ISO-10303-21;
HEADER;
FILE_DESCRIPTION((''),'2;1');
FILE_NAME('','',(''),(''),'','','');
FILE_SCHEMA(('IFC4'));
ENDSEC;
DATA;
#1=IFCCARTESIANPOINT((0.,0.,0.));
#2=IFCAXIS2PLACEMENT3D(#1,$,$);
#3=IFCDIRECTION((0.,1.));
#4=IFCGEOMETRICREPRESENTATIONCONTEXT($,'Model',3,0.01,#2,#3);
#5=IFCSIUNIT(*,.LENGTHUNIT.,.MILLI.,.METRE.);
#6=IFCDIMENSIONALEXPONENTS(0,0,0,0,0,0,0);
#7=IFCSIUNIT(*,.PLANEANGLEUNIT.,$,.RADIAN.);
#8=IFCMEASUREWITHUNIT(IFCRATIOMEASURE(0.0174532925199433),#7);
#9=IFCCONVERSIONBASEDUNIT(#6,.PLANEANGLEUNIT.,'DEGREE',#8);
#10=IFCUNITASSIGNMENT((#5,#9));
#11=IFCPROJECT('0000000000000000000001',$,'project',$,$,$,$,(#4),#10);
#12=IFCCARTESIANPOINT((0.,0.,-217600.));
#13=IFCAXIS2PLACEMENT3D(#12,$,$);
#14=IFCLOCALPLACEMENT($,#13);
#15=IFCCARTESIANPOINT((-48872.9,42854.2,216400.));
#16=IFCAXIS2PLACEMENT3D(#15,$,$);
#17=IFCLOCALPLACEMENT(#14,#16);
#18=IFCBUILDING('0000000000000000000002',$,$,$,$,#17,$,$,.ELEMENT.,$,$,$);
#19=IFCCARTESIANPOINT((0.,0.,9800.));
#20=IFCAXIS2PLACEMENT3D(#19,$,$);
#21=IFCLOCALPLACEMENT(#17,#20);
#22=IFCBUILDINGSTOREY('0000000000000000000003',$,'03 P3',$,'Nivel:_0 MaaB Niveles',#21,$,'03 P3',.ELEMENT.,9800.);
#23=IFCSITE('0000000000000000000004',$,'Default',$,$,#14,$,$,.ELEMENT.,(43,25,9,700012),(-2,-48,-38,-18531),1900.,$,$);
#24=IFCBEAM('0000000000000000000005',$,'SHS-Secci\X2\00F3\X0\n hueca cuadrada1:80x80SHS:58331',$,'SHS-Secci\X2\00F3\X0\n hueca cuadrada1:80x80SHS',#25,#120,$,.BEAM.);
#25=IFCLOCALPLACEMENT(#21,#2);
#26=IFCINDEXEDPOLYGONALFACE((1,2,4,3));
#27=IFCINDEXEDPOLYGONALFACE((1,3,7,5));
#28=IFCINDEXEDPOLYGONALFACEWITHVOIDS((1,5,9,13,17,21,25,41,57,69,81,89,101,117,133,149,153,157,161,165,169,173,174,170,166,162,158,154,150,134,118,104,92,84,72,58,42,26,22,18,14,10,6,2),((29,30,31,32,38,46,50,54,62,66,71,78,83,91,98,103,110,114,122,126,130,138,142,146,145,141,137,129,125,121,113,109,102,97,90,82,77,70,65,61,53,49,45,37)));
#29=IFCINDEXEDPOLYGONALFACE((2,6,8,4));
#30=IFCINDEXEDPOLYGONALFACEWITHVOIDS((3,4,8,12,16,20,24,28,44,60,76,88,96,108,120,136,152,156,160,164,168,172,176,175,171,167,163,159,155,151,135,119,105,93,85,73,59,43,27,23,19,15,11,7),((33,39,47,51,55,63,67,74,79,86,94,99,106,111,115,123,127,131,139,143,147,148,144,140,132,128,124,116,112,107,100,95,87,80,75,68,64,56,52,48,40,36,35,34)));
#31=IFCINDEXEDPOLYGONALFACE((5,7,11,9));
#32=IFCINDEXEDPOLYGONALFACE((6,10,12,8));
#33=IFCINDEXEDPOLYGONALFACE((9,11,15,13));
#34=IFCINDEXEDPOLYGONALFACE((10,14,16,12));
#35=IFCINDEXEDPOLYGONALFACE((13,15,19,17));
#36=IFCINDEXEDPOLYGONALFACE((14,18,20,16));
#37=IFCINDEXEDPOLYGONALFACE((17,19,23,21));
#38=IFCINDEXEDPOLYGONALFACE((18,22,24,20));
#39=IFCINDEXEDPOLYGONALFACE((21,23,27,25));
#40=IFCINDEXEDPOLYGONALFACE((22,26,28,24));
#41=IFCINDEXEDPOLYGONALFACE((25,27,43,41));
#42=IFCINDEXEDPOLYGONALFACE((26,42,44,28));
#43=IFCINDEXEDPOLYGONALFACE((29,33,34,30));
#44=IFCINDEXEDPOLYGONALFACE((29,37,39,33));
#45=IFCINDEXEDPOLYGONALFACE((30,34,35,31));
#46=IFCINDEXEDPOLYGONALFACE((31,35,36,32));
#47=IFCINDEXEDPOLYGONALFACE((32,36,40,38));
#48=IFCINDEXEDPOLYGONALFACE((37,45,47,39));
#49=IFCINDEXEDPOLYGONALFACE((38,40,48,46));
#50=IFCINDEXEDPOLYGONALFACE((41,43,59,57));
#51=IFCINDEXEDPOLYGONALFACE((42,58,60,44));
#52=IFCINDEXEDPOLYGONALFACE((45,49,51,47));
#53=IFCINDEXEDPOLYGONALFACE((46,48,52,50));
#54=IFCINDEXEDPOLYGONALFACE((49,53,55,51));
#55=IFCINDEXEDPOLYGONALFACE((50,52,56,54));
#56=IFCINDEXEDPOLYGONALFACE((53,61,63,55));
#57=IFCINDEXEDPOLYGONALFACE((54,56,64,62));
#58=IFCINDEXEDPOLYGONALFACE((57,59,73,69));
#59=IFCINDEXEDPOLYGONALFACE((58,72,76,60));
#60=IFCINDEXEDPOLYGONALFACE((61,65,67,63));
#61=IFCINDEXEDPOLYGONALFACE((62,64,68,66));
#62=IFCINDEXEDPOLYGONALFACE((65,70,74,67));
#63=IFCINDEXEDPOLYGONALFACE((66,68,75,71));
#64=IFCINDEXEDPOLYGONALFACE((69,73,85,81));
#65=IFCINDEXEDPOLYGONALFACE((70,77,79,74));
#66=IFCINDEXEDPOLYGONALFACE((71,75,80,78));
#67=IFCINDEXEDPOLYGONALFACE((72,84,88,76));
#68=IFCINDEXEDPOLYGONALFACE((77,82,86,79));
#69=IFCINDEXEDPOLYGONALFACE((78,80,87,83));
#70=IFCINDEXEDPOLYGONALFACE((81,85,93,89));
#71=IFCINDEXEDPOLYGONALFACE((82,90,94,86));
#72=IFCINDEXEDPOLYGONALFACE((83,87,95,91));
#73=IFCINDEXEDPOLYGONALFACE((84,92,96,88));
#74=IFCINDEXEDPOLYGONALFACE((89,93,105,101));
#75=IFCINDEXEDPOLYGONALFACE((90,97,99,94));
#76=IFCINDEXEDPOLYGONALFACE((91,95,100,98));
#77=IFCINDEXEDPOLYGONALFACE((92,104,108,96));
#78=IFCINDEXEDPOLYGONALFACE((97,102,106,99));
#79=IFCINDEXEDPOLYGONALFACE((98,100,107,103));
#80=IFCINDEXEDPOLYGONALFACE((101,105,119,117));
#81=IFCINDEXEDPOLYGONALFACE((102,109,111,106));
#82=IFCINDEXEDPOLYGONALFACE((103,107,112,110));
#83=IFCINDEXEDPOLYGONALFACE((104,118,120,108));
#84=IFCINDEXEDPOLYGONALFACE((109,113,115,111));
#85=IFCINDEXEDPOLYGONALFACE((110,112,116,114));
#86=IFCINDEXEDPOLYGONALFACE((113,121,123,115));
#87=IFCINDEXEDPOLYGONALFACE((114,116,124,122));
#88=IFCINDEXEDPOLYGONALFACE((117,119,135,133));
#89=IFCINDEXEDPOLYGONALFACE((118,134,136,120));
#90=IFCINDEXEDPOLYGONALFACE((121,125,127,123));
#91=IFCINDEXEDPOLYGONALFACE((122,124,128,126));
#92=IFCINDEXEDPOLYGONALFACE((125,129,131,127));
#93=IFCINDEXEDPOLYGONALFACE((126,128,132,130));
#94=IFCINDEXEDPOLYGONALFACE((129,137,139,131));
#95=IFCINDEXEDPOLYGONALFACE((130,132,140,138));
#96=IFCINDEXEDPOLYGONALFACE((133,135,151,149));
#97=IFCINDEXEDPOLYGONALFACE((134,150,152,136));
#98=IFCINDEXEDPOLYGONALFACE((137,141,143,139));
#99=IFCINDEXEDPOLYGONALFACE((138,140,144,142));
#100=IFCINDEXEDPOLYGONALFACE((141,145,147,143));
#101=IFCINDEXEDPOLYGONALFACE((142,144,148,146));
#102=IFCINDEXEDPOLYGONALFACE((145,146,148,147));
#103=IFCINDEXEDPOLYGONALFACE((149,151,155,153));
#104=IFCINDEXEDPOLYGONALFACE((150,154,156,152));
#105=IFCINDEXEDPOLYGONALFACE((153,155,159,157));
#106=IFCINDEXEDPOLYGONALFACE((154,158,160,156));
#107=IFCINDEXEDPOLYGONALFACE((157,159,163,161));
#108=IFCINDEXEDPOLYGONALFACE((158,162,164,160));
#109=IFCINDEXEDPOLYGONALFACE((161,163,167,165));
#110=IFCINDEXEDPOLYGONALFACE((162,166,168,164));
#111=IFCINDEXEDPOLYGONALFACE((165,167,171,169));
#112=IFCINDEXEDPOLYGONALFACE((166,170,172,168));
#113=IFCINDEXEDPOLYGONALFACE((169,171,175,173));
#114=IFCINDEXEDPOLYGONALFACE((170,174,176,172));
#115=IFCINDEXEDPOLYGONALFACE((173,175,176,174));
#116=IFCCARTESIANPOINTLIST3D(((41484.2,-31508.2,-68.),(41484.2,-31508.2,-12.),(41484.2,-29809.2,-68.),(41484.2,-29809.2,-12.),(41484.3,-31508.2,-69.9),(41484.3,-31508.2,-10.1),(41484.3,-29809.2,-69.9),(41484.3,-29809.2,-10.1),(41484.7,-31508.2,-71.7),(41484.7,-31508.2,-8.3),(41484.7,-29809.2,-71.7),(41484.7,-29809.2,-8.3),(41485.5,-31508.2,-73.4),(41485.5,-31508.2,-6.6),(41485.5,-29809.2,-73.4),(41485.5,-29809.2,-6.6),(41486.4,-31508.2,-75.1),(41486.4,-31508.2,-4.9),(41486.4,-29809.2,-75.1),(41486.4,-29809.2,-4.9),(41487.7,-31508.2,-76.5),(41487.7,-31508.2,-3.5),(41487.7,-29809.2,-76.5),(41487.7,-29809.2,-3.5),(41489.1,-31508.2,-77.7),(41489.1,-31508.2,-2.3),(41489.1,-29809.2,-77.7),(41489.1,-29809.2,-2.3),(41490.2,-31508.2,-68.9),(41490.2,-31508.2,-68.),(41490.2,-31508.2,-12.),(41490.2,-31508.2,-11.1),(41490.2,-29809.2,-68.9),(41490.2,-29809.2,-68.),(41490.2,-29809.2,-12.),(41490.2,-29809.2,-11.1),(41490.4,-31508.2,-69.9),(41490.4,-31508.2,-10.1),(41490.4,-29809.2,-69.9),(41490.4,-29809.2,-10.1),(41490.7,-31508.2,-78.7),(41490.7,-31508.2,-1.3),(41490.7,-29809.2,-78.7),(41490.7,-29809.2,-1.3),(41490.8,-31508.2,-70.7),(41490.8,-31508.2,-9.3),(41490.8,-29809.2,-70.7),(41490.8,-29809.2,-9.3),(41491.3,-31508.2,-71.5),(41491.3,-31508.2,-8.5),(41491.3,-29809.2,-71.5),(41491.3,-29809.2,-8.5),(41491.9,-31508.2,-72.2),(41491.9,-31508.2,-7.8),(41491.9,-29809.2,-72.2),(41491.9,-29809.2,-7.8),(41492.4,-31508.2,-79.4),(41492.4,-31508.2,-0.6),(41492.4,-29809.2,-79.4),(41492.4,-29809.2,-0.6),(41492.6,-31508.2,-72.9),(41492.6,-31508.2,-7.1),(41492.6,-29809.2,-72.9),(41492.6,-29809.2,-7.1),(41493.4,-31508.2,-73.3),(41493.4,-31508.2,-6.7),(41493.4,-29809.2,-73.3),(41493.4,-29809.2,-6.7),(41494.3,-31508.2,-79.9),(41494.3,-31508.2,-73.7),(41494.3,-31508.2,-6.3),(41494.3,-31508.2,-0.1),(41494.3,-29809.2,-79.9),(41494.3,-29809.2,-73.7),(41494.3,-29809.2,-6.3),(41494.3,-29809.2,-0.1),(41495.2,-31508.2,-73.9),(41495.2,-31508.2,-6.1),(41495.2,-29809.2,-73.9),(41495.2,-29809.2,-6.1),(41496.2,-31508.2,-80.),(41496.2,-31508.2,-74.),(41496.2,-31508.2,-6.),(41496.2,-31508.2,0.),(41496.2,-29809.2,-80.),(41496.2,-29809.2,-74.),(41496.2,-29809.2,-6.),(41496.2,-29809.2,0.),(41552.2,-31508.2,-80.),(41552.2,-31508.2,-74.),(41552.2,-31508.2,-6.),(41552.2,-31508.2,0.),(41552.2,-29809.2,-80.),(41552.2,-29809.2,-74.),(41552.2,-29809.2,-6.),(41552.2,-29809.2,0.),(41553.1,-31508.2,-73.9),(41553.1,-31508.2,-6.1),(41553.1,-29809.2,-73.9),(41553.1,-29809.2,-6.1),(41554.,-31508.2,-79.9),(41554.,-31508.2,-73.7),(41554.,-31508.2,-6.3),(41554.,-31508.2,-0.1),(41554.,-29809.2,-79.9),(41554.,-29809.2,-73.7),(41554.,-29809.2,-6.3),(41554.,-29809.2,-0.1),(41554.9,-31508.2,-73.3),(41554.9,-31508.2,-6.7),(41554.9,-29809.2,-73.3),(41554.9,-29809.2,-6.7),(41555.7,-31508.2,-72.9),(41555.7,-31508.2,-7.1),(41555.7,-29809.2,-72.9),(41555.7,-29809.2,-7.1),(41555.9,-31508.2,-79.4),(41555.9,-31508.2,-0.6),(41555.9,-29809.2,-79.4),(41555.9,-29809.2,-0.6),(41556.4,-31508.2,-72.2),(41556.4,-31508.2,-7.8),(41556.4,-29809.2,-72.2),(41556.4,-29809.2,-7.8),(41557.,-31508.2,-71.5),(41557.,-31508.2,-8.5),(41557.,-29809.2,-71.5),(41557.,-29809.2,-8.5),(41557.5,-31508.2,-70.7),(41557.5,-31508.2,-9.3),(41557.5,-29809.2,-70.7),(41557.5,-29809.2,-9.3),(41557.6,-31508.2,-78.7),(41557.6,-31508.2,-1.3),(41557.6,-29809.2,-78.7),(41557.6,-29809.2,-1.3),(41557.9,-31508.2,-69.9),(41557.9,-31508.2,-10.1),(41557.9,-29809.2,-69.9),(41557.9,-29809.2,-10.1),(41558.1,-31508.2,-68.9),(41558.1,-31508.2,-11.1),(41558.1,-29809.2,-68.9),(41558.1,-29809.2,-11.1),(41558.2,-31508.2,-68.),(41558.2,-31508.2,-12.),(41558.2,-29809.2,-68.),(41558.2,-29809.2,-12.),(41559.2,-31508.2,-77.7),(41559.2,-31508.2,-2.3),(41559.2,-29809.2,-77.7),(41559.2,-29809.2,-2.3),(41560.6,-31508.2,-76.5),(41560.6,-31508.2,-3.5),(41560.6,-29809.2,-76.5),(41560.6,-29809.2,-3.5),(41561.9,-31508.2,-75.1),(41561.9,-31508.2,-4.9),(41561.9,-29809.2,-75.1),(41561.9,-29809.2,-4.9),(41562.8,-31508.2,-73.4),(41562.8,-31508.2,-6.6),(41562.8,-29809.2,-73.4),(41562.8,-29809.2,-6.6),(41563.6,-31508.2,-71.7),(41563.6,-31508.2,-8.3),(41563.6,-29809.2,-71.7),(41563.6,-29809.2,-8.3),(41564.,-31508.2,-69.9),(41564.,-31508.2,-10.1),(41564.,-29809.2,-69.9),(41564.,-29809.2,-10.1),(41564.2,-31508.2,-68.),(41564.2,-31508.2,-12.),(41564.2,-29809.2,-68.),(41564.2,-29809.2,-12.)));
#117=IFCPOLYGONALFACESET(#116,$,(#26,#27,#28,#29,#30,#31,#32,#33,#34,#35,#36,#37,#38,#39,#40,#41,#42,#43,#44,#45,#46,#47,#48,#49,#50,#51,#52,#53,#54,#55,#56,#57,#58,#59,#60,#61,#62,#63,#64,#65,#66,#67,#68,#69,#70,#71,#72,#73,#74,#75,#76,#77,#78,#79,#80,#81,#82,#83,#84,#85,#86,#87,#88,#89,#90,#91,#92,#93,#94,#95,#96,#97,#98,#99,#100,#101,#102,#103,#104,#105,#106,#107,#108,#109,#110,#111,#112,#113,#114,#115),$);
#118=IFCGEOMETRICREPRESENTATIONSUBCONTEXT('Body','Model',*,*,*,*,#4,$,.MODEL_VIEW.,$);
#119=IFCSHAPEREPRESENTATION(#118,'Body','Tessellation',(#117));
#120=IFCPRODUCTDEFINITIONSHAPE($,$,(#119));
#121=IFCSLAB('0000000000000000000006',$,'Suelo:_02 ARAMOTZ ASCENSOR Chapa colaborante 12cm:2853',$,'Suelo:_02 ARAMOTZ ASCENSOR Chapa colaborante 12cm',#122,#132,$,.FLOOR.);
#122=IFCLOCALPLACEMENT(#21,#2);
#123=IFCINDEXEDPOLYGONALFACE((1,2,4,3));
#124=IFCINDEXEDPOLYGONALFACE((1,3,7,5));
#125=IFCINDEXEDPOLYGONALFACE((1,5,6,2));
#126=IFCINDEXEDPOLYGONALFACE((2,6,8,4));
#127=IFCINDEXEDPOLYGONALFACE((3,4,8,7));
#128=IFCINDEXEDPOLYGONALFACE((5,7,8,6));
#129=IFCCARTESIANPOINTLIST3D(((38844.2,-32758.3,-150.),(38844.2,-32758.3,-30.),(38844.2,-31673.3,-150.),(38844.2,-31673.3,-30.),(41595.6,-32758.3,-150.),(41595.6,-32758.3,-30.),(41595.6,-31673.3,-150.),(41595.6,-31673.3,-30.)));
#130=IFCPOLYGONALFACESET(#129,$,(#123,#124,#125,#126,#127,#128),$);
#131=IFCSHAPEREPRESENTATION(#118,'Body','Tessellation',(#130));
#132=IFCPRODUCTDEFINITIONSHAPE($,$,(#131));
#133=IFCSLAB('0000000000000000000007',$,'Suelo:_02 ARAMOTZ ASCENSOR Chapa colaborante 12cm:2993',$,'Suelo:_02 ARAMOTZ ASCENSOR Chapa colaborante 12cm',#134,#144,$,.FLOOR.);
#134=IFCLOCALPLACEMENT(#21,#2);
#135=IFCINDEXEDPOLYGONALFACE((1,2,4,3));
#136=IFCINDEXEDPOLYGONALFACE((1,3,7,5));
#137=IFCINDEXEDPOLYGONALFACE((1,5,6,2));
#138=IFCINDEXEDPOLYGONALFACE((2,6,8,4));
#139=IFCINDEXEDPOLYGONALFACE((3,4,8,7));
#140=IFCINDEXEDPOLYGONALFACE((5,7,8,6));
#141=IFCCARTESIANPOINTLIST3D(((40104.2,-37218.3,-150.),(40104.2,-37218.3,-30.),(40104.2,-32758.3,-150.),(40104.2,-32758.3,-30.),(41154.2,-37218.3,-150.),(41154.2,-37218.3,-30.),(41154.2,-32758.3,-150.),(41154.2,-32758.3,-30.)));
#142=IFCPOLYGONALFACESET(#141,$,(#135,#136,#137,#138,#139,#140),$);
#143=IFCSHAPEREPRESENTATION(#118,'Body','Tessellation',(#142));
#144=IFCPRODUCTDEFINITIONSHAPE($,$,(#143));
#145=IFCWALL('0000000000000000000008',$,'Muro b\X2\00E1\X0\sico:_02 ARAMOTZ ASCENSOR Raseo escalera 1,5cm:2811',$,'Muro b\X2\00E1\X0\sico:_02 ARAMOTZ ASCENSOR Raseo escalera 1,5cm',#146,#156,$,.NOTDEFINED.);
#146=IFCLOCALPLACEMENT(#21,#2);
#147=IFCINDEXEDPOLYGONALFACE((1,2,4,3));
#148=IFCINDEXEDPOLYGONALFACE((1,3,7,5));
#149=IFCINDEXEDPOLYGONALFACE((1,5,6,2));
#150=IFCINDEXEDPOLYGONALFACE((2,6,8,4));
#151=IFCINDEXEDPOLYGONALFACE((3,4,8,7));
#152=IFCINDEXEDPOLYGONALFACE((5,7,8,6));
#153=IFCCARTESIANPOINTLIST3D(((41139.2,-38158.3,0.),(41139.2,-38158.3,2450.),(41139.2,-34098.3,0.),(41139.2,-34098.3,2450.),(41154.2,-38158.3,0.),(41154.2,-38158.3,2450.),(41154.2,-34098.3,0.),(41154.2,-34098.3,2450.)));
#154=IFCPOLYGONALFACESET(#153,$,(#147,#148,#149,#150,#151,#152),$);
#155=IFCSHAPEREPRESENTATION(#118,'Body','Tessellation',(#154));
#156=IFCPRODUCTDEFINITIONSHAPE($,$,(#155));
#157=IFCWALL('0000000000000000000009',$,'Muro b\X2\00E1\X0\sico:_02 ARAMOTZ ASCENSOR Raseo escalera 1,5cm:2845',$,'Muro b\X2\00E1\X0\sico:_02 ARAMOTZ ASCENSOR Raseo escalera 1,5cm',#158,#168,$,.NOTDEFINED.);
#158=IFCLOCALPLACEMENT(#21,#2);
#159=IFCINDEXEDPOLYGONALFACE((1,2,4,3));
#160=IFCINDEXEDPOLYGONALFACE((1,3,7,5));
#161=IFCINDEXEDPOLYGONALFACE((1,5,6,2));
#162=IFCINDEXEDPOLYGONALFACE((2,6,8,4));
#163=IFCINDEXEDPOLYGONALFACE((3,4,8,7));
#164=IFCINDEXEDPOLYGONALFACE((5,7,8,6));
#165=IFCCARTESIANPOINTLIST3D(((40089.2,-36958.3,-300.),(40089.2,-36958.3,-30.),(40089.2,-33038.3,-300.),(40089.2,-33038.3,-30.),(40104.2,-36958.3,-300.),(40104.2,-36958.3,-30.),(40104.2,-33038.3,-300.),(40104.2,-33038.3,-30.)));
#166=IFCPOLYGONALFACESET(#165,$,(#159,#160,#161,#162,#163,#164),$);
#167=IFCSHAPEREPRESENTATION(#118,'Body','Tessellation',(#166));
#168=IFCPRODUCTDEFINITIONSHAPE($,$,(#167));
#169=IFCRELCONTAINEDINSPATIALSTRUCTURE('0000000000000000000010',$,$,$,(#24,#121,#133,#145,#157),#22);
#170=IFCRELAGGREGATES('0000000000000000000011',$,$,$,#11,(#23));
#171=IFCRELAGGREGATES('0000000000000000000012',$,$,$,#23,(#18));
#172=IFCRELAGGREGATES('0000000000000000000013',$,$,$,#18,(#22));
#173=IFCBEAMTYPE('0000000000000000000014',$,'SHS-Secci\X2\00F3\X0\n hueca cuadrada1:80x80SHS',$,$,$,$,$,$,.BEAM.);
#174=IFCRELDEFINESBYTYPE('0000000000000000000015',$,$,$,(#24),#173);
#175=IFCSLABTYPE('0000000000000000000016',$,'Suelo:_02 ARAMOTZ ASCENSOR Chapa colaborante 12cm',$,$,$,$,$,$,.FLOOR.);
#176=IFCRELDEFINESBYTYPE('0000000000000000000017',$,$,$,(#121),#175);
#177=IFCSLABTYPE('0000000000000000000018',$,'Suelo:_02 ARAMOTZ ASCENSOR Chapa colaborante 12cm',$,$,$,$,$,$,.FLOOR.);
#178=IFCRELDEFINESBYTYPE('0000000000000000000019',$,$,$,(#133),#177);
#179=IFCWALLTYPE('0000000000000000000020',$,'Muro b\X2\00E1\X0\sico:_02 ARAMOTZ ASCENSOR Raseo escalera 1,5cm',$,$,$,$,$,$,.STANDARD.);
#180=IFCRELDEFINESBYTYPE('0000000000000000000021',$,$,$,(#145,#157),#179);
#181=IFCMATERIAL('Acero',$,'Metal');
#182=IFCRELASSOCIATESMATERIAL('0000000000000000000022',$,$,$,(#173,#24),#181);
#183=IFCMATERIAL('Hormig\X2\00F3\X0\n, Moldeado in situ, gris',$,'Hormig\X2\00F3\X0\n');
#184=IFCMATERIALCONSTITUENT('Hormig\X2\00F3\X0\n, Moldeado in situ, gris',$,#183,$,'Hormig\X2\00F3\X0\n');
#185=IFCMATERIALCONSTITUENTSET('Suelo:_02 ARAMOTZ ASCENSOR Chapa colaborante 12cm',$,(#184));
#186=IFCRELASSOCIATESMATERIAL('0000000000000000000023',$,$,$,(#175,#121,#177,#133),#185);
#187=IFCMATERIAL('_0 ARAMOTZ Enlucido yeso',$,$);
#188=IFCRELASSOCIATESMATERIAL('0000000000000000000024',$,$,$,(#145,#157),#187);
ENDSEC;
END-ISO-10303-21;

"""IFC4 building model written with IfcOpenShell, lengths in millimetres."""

from ifc_helpers import new_model, entity, si_unit, converted_unit, direction, frame, origin, place, context, subcontext, project, spatial, indexed_curve, outline, extrude, source, transform, mapped, material, constituent, constituent_set, type_object, type_shapes, element, save


model = new_model("IFC4")

# Units and contexts
model_context = context("Model", 3, precision=0.01, world=origin(), true_north=direction((0.0, 1.0)))
body_context = subcontext(model_context, "Body", "Model", "MODEL_VIEW")
ifc_project = project(units=[si_unit("LENGTHUNIT", "METRE", prefix="MILLI"), converted_unit("PLANEANGLEUNIT", "DEGREE", entity("IfcRatioMeasure", 0.0174532925199433), si_unit("PLANEANGLEUNIT", "RADIAN"), dimensions=[0, 0, 0, 0, 0, 0, 0])], contexts=[model_context])

# Site, building, storey
site_placement = place(None, frame((0.0, 0.0, -217600.0)))
site = spatial("IfcSite", under=ifc_project, at=site_placement, Name="Default", CompositionType="ELEMENT", RefLatitude=(43, 25, 9, 700012), RefLongitude=(-2, -48, -38, -18531), RefElevation=1900.0)
building_placement = place(site_placement, frame((-48872.9, 42854.2, 216400.0)))
building = spatial("IfcBuilding", under=site, at=building_placement, CompositionType="ELEMENT")
storey_placement = place(building_placement, frame((0.0, 0.0, 9800.0)))
storey = spatial("IfcBuildingStorey", under=building, at=storey_placement, Name="03 P3", ObjectType="Nivel:_0 MaaB Niveles", LongName="03 P3", CompositionType="ELEMENT", Elevation=9800.0)

# Shared definitions
ifc_material_1 = material(Name="Acero", Category="Metal")

# Beam
beam_type_1 = type_object("IfcBeamType", Name="SHS-Sección hueca cuadrada1:80x80SHS", PredefinedType="BEAM", material=ifc_material_1)
shared_shape_1 = source(origin(), body_context, "Body", "SweptSolid", [
    extrude(outline(indexed_curve([(-40.0, -28.0), (-39.9, -29.9), (-39.4, -31.7), (-38.7, -33.4), (-37.7, -35.1), (-36.5, -36.5), (-35.1, -37.7), (-33.4, -38.7), (-31.7, -39.4), (-29.9, -39.9), (-28.0, -40.0), (28.0, -40.0), (29.9, -39.9), (31.7, -39.4), (33.4, -38.7), (35.1, -37.7), (36.5, -36.5), (37.7, -35.1), (38.7, -33.4), (39.4, -31.7), (39.9, -29.9), (40.0, -28.0), (40.0, 28.0), (39.9, 29.9), (39.4, 31.7), (38.7, 33.4), (37.7, 35.1), (36.5, 36.5), (35.1, 37.7), (33.4, 38.7), (31.7, 39.4), (29.9, 39.9), (28.0, 40.0), (-28.0, 40.0), (-29.9, 39.9), (-31.7, 39.4), (-33.4, 38.7), (-35.1, 37.7), (-36.5, 36.5), (-37.7, 35.1), (-38.7, 33.4), (-39.4, 31.7), (-39.9, 29.9), (-40.0, 28.0), (-40.0, -28.0)], self_intersect=False), holes=[indexed_curve([(28.0, -34.0), (-28.0, -34.0), (-28.9, -33.9), (-29.9, -33.7), (-30.7, -33.3), (-31.5, -32.9), (-32.2, -32.2), (-32.9, -31.5), (-33.3, -30.7), (-33.7, -29.9), (-33.9, -28.9), (-34.0, -28.0), (-34.0, 28.0), (-33.9, 28.9), (-33.7, 29.9), (-33.3, 30.7), (-32.9, 31.5), (-32.2, 32.2), (-31.5, 32.9), (-30.7, 33.3), (-29.9, 33.7), (-28.9, 33.9), (-28.0, 34.0), (28.0, 34.0), (28.9, 33.9), (29.9, 33.7), (30.7, 33.3), (31.5, 32.9), (32.2, 32.2), (32.9, 31.5), (33.3, 30.7), (33.7, 29.9), (33.9, 28.9), (34.0, 28.0), (34.0, -28.0), (33.9, -28.9), (33.7, -29.9), (33.3, -30.7), (32.9, -31.5), (32.2, -32.2), (31.5, -32.9), (30.7, -33.3), (29.9, -33.7), (28.9, -33.9), (28.0, -34.0)], self_intersect=False)]), frame((-827.0, 0.0, 0.0), z_axis=(1.0, 0.0, 0.0), x_axis=(0.0, -1.0, 0.0)), (0.0, 0.0, 1.0), 1699.0),
])
type_shapes(beam_type_1, [shared_shape_1])
beam_1_placement = place(storey_placement, frame((41524.2, -30636.2, -40.0), z_axis=(0.0, 0.0, 1.0), x_axis=(0.0, -1.0, 0.0)))
element("IfcBeam", 1, at=beam_1_placement, inside=storey, type_object=beam_type_1, material=ifc_material_1, Name="SHS-Sección hueca cuadrada1:80x80SHS:58331", ObjectType="SHS-Sección hueca cuadrada1:80x80SHS", PredefinedType="BEAM", context=body_context, shape_type="MappedRepresentation", body=[
    mapped(shared_shape_1, transform((0.0, 0.0, 0.0), scale=1.0)),
])

# Slabs
ifc_material_2 = material(Name="Hormigón, Moldeado in situ, gris", Category="Hormigón")
ifc_constituent_1 = constituent(ifc_material_2, Name="Hormigón, Moldeado in situ, gris", Category="Hormigón")
ifc_constituent_set_1 = constituent_set(constituents=[ifc_constituent_1], Name="Suelo:_02 ARAMOTZ ASCENSOR Chapa colaborante 12cm")
slab_type_1 = type_object("IfcSlabType", Name="Suelo:_02 ARAMOTZ ASCENSOR Chapa colaborante 12cm", PredefinedType="FLOOR", material=ifc_constituent_set_1)
slab_1_placement = place(storey_placement, origin())
element("IfcSlab", 2, at=slab_1_placement, inside=storey, type_object=slab_type_1, material=ifc_constituent_set_1, Name="Suelo:_02 ARAMOTZ ASCENSOR Chapa colaborante 12cm:2853", ObjectType="Suelo:_02 ARAMOTZ ASCENSOR Chapa colaborante 12cm", PredefinedType="FLOOR", context=body_context, shape_type="SweptSolid", body=[
    extrude(outline(indexed_curve([(-542.5, -1375.7), (542.5, -1375.7), (542.5, 1375.7), (-542.5, 1375.7), (-542.5, -1375.7)], self_intersect=False)), frame((40219.9, -32215.8, -30.0), z_axis=(0.0, 0.0, -1.0), x_axis=(0.0, -1.0, 0.0)), (0.0, 0.0, 1.0), 120.0),
])
slab_type_2 = type_object("IfcSlabType", Name="Suelo:_02 ARAMOTZ ASCENSOR Chapa colaborante 12cm", PredefinedType="FLOOR", material=ifc_constituent_set_1)
slab_2_placement = place(storey_placement, origin())
element("IfcSlab", 3, at=slab_2_placement, inside=storey, type_object=slab_type_2, material=ifc_constituent_set_1, Name="Suelo:_02 ARAMOTZ ASCENSOR Chapa colaborante 12cm:2993", ObjectType="Suelo:_02 ARAMOTZ ASCENSOR Chapa colaborante 12cm", PredefinedType="FLOOR", context=body_context, shape_type="SweptSolid", body=[
    extrude(outline(indexed_curve([(-525.0, -2230.0), (525.0, -2230.0), (525.0, 2230.0), (-525.0, 2230.0), (-525.0, -2230.0)], self_intersect=False)), frame((40629.2, -34988.3, -30.0), z_axis=(0.0, 0.0, -1.0), x_axis=(1.0, 0.0, 0.0)), (0.0, 0.0, 1.0), 120.0),
])

# Walls
ifc_material_3 = material(Name="_0 ARAMOTZ Enlucido yeso")
wall_type_1 = type_object("IfcWallType", Name="Muro básico:_02 ARAMOTZ ASCENSOR Raseo escalera 1,5cm", PredefinedType="STANDARD")
wall_1_placement = place(storey_placement, frame((41146.7, -38158.3, 0.0), z_axis=(0.0, 0.0, 1.0), x_axis=(0.0, 1.0, 0.0)))
element("IfcWall", 4, at=wall_1_placement, inside=storey, type_object=wall_type_1, material=ifc_material_3, Name="Muro básico:_02 ARAMOTZ ASCENSOR Raseo escalera 1,5cm:2811", ObjectType="Muro básico:_02 ARAMOTZ ASCENSOR Raseo escalera 1,5cm", PredefinedType="NOTDEFINED", context=body_context, shape_type="SweptSolid", body=[
    extrude(outline(indexed_curve([(4060.0, 7.5), (0.0, 7.5), (0.0, -7.5), (4060.0, -7.5), (4060.0, 7.5)], self_intersect=False)), origin(), (0.0, 0.0, 1.0), 2450.0),
])
wall_2_placement = place(storey_placement, frame((40096.7, -36958.3, -300.0), z_axis=(0.0, 0.0, 1.0), x_axis=(0.0, 1.0, 0.0)))
element("IfcWall", 5, at=wall_2_placement, inside=storey, type_object=wall_type_1, material=ifc_material_3, Name="Muro básico:_02 ARAMOTZ ASCENSOR Raseo escalera 1,5cm:2845", ObjectType="Muro básico:_02 ARAMOTZ ASCENSOR Raseo escalera 1,5cm", PredefinedType="NOTDEFINED", context=body_context, shape_type="SweptSolid", body=[
    extrude(outline(indexed_curve([(3920.0, 7.5), (0.0, 7.5), (0.0, -7.5), (3920.0, -7.5), (3920.0, 7.5)], self_intersect=False)), origin(), (0.0, 0.0, 1.0), 270.0),
])

save(model, "model.ifc")
